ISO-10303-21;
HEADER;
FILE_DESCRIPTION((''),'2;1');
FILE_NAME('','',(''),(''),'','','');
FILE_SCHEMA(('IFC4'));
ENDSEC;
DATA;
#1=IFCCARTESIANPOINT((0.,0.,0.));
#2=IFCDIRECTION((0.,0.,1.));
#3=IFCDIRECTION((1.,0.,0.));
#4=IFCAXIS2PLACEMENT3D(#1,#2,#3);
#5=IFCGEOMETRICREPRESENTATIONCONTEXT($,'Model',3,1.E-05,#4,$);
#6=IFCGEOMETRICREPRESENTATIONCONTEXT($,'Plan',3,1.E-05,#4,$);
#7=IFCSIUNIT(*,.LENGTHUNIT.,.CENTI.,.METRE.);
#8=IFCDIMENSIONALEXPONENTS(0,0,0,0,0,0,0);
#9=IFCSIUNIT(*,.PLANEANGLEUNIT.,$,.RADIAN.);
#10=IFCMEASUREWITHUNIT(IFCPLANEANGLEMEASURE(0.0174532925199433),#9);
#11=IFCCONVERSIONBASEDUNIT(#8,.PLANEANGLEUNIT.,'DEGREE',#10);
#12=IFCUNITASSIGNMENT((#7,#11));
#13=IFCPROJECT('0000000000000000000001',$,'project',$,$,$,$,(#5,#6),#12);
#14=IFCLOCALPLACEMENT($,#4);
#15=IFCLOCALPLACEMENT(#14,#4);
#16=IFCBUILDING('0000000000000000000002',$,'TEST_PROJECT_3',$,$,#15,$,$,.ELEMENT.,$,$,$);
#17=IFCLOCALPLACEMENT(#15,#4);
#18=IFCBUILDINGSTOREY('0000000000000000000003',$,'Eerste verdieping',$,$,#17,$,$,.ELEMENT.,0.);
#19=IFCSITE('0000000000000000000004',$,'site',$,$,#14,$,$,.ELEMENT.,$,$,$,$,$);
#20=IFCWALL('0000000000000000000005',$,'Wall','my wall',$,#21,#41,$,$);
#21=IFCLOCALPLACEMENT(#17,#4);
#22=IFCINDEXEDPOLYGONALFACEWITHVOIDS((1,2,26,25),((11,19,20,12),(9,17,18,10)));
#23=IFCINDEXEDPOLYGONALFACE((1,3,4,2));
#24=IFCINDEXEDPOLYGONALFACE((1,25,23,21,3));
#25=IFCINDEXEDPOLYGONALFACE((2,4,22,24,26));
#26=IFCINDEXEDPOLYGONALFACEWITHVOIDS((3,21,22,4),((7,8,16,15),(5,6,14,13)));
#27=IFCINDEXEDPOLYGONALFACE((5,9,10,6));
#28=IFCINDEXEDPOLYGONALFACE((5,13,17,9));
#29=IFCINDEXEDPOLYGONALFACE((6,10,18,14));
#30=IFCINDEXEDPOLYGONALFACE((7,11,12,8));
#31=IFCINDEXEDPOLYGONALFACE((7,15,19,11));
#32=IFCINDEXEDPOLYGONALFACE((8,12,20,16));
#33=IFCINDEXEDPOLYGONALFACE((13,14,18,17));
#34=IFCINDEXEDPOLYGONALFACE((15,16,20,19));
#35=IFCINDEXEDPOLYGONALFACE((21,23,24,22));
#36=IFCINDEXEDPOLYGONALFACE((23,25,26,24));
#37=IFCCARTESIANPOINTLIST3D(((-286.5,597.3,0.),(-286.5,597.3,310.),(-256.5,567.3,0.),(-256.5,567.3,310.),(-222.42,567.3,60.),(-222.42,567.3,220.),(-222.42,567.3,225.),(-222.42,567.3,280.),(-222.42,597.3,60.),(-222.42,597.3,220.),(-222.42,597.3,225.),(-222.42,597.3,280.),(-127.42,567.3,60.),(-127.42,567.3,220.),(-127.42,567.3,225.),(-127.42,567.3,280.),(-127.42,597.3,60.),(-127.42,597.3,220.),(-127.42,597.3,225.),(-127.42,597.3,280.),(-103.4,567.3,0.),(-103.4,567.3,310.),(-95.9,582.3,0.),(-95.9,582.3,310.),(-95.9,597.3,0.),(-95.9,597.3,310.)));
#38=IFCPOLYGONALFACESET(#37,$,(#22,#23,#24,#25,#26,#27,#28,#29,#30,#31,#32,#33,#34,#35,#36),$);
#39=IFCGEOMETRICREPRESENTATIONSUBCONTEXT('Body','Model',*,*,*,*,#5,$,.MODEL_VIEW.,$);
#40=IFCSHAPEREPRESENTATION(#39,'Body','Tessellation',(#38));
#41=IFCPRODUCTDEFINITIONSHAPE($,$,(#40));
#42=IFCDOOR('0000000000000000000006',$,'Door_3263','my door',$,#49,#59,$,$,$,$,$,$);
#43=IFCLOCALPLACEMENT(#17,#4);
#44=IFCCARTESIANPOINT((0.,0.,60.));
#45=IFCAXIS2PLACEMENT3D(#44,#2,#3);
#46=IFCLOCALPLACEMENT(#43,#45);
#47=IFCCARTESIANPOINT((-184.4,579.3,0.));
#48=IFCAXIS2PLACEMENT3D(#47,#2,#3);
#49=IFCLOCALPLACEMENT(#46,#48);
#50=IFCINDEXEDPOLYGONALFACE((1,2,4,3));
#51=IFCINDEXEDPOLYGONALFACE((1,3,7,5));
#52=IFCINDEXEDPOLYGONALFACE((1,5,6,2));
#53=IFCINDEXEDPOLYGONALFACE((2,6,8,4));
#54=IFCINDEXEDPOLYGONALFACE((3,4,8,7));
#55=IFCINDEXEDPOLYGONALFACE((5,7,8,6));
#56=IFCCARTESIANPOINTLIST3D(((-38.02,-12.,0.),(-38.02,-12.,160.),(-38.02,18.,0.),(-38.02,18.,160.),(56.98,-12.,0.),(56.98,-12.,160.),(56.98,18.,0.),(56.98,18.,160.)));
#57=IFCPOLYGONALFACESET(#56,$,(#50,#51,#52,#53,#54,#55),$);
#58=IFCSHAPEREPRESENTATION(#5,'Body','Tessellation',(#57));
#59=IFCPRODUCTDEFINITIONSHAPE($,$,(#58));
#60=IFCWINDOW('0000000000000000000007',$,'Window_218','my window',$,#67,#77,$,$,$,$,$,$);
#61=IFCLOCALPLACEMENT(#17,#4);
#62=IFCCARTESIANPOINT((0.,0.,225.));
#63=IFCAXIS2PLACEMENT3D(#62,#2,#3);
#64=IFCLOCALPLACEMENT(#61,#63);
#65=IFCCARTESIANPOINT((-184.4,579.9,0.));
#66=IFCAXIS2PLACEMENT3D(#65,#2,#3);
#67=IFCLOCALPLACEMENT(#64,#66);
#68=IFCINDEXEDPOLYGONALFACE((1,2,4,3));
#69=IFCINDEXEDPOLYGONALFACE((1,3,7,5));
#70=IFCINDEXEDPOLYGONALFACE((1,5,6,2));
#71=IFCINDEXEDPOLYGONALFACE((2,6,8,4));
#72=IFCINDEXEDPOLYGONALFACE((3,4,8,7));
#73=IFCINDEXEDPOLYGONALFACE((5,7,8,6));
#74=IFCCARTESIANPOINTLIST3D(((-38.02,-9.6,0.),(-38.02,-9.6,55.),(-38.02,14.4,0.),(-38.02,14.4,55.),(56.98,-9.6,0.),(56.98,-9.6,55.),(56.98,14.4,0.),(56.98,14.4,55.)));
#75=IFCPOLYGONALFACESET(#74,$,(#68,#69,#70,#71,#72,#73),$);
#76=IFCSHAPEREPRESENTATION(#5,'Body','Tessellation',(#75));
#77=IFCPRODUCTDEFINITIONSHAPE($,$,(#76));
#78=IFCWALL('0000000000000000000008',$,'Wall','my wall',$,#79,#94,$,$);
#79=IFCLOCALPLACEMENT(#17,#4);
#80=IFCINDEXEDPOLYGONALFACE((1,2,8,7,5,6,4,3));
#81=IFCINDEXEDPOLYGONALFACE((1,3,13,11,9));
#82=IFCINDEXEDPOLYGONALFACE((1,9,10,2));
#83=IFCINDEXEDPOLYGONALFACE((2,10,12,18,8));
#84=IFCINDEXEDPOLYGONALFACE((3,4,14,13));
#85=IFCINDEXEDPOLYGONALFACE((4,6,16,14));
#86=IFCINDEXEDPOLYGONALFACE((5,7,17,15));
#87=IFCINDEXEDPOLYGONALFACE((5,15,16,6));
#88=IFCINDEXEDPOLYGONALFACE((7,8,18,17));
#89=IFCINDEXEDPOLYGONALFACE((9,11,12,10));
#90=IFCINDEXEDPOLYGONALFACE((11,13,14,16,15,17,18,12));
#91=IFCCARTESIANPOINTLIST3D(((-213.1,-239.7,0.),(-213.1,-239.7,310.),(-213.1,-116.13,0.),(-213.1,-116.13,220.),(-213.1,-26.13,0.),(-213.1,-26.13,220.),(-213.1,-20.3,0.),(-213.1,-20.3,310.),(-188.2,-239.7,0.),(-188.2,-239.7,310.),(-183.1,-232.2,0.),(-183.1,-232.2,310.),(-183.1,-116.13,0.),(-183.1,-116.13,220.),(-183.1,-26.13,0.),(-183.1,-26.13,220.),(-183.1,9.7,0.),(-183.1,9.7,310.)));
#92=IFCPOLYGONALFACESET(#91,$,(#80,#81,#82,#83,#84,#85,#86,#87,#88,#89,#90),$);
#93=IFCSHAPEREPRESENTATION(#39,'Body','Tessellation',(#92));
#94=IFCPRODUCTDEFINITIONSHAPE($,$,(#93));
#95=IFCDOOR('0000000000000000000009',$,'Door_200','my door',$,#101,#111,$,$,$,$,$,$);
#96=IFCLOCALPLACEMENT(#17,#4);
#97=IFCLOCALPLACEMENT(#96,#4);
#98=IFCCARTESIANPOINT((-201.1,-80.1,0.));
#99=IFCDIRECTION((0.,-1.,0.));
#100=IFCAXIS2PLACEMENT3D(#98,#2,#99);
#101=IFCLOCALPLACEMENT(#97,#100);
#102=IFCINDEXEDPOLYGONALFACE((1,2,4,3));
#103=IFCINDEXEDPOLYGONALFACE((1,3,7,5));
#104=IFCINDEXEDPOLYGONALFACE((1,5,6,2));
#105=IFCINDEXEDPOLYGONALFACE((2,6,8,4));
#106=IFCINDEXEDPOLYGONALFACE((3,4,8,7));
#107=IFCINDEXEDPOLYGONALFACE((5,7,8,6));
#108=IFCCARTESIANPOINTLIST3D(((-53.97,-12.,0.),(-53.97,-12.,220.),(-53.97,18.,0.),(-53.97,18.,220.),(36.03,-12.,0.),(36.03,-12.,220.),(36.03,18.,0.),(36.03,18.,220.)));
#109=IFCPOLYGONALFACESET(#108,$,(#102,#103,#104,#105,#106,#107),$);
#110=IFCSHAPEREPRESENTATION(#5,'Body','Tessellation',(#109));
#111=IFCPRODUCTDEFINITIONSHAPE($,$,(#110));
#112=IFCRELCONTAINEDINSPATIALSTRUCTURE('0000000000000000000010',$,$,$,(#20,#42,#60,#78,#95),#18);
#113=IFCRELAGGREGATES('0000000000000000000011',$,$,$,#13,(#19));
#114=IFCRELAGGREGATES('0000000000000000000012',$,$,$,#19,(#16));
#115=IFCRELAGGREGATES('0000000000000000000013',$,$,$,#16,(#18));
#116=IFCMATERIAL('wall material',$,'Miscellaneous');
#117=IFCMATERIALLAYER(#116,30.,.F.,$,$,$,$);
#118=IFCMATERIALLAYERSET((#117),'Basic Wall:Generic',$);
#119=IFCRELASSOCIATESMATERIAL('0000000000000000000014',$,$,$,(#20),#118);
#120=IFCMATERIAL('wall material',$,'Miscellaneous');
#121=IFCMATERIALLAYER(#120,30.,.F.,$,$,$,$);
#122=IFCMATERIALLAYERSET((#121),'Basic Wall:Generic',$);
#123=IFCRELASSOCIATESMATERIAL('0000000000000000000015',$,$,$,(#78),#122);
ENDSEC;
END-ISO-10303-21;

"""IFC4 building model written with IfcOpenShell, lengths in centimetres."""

from ifc_helpers import new_model, entity, si_unit, converted_unit, frame, origin_with_axes, place, context, subcontext, project, spatial, polyline, outline, extrude, material, layer, layer_set, layer_usage, element, fill, save


model = new_model("IFC4")

# Units and contexts
model_context = context("Model", 3, precision=1e-05, world=origin_with_axes())
plan_context = context("Plan", 3, precision=1e-05, world=origin_with_axes())
body_context = subcontext(model_context, "Body", "Model", "MODEL_VIEW")
ifc_project = project(units=[si_unit("LENGTHUNIT", "METRE", prefix="CENTI"), converted_unit("PLANEANGLEUNIT", "DEGREE", entity("IfcPlaneAngleMeasure", 0.0174532925199433), si_unit("PLANEANGLEUNIT", "RADIAN"), dimensions=[0, 0, 0, 0, 0, 0, 0])], contexts=[model_context, plan_context])

# Site, building, storey
site_placement = place(None, origin_with_axes())
site = spatial("IfcSite", under=ifc_project, at=site_placement, Name="site", CompositionType="ELEMENT")
building_placement = place(site_placement, origin_with_axes())
building = spatial("IfcBuilding", under=site, at=building_placement, Name="TEST_PROJECT_3", CompositionType="ELEMENT")
storey_placement = place(building_placement, origin_with_axes())
storey = spatial("IfcBuildingStorey", under=building, at=storey_placement, Name="Eerste verdieping", CompositionType="ELEMENT", Elevation=0.0)

# Wall, openings, door, window
ifc_material_1 = material(Name="wall material", Category="Miscellaneous")
ifc_layer_1 = layer(ifc_material_1, 30.0, ventilated=False)
ifc_layer_set_1 = layer_set([ifc_layer_1], Name="Basic Wall:Generic")
ifc_layer_usage_1 = layer_usage(ifc_layer_set_1, "AXIS3", "NEGATIVE", 0.0)
wall_1_placement = place(storey_placement, origin_with_axes())
wall_1 = element("IfcWall", 1, at=wall_1_placement, inside=storey, material=ifc_layer_usage_1, Name="Wall", Description="my wall", context=body_context, shape_type="SweptSolid", body=[
    extrude(outline(polyline([(-256.5, 567.3, 0.0), (-286.5, 597.3, 0.0), (-95.9, 597.3, 0.0), (-95.9, 582.3, 0.0), (-103.4, 567.3, 0.0), (-256.5, 567.3, 0.0)])), origin_with_axes(), (0.0, 0.0, 1.0), 310.0),
])
placement_1 = place(storey_placement, origin_with_axes())
opening_1_placement = place(placement_1, frame((0.0, 0.0, 60.0), z_axis=(0.0, 0.0, 1.0), x_axis=(1.0, 0.0, 0.0)))
opening_1 = element("IfcOpeningElement", 2, at=opening_1_placement, cuts=wall_1, context=model_context, shape_type="SweptSolid", body=[
    extrude(outline(polyline([(-222.42, 567.3, 0.0), (-222.42, 597.3, 0.0), (-127.42, 597.3, 0.0), (-127.42, 567.3, 0.0), (-222.42, 567.3, 0.0)])), origin_with_axes(), (0.0, 0.0, 1.0), 160.0),
])
placement_2 = place(storey_placement, origin_with_axes())
opening_2_placement = place(placement_2, frame((0.0, 0.0, 225.0), z_axis=(0.0, 0.0, 1.0), x_axis=(1.0, 0.0, 0.0)))
opening_2 = element("IfcOpeningElement", 3, at=opening_2_placement, cuts=wall_1, context=model_context, shape_type="SweptSolid", body=[
    extrude(outline(polyline([(-222.42, 567.3, 0.0), (-222.42, 597.3, 0.0), (-127.42, 597.3, 0.0), (-127.42, 567.3, 0.0), (-222.42, 567.3, 0.0)])), origin_with_axes(), (0.0, 0.0, 1.0), 55.0),
])
door_1_placement = place(opening_1_placement, frame((-184.4, 579.3, 0.0), z_axis=(0.0, 0.0, 1.0), x_axis=(1.0, 0.0, 0.0)))
door_1 = element("IfcDoor", 4, at=door_1_placement, inside=storey, Name="Door_3263", Description="my door", context=model_context, shape_type="SweptSolid", body=[
    extrude(outline(polyline([(-38.02, -12.0), (-38.02, 18.0), (56.98, 18.0), (56.98, -12.0), (-38.02, -12.0)])), origin_with_axes(), (0.0, 0.0, 1.0), 160.0),
])
fill(opening_1, door_1)
window_1_placement = place(opening_2_placement, frame((-184.4, 579.9, 0.0), z_axis=(0.0, 0.0, 1.0), x_axis=(1.0, 0.0, 0.0)))
window_1 = element("IfcWindow", 5, at=window_1_placement, inside=storey, Name="Window_218", Description="my window", context=model_context, shape_type="SweptSolid", body=[
    extrude(outline(polyline([(-38.02, -9.6), (-38.02, 14.4), (56.98, 14.4), (56.98, -9.6), (-38.02, -9.6)])), origin_with_axes(), (0.0, 0.0, 1.0), 55.0),
])
fill(opening_2, window_1)

# Wall, opening, door
ifc_material_2 = material(Name="wall material", Category="Miscellaneous")
ifc_layer_2 = layer(ifc_material_2, 30.0, ventilated=False)
ifc_layer_set_2 = layer_set([ifc_layer_2], Name="Basic Wall:Generic")
ifc_layer_usage_2 = layer_usage(ifc_layer_set_2, "AXIS3", "NEGATIVE", 0.0)
wall_2_placement = place(storey_placement, origin_with_axes())
wall_2 = element("IfcWall", 6, at=wall_2_placement, inside=storey, material=ifc_layer_usage_2, Name="Wall", Description="my wall", context=body_context, shape_type="SweptSolid", body=[
    extrude(outline(polyline([(-213.1, -239.7, 0.0), (-213.1, -20.3, 0.0), (-183.1, 9.7, 0.0), (-183.1, -232.2, 0.0), (-188.2, -239.7, 0.0), (-213.1, -239.7, 0.0)])), origin_with_axes(), (0.0, 0.0, 1.0), 310.0),
])
placement_3 = place(storey_placement, origin_with_axes())
opening_3_placement = place(placement_3, origin_with_axes())
opening_3 = element("IfcOpeningElement", 7, at=opening_3_placement, cuts=wall_2, context=model_context, shape_type="SweptSolid", body=[
    extrude(outline(polyline([(-213.1, -116.13, 0.0), (-213.1, -26.13, 0.0), (-183.1, -26.13, 0.0), (-183.1, -116.13, 0.0), (-213.1, -116.13, 0.0)])), origin_with_axes(), (0.0, 0.0, 1.0), 220.0),
])
door_2_placement = place(opening_3_placement, frame((-201.1, -80.1, 0.0), z_axis=(0.0, 0.0, 1.0), x_axis=(0.0, -1.0, 0.0)))
door_2 = element("IfcDoor", 8, at=door_2_placement, inside=storey, Name="Door_200", Description="my door", context=model_context, shape_type="SweptSolid", body=[
    extrude(outline(polyline([(36.03, -12.0), (-53.97, -12.0), (-53.97, 18.0), (36.03, 18.0), (36.03, -12.0)])), origin_with_axes(), (0.0, 0.0, 1.0), 220.0),
])
fill(opening_3, door_2)

save(model, "model.ifc")
